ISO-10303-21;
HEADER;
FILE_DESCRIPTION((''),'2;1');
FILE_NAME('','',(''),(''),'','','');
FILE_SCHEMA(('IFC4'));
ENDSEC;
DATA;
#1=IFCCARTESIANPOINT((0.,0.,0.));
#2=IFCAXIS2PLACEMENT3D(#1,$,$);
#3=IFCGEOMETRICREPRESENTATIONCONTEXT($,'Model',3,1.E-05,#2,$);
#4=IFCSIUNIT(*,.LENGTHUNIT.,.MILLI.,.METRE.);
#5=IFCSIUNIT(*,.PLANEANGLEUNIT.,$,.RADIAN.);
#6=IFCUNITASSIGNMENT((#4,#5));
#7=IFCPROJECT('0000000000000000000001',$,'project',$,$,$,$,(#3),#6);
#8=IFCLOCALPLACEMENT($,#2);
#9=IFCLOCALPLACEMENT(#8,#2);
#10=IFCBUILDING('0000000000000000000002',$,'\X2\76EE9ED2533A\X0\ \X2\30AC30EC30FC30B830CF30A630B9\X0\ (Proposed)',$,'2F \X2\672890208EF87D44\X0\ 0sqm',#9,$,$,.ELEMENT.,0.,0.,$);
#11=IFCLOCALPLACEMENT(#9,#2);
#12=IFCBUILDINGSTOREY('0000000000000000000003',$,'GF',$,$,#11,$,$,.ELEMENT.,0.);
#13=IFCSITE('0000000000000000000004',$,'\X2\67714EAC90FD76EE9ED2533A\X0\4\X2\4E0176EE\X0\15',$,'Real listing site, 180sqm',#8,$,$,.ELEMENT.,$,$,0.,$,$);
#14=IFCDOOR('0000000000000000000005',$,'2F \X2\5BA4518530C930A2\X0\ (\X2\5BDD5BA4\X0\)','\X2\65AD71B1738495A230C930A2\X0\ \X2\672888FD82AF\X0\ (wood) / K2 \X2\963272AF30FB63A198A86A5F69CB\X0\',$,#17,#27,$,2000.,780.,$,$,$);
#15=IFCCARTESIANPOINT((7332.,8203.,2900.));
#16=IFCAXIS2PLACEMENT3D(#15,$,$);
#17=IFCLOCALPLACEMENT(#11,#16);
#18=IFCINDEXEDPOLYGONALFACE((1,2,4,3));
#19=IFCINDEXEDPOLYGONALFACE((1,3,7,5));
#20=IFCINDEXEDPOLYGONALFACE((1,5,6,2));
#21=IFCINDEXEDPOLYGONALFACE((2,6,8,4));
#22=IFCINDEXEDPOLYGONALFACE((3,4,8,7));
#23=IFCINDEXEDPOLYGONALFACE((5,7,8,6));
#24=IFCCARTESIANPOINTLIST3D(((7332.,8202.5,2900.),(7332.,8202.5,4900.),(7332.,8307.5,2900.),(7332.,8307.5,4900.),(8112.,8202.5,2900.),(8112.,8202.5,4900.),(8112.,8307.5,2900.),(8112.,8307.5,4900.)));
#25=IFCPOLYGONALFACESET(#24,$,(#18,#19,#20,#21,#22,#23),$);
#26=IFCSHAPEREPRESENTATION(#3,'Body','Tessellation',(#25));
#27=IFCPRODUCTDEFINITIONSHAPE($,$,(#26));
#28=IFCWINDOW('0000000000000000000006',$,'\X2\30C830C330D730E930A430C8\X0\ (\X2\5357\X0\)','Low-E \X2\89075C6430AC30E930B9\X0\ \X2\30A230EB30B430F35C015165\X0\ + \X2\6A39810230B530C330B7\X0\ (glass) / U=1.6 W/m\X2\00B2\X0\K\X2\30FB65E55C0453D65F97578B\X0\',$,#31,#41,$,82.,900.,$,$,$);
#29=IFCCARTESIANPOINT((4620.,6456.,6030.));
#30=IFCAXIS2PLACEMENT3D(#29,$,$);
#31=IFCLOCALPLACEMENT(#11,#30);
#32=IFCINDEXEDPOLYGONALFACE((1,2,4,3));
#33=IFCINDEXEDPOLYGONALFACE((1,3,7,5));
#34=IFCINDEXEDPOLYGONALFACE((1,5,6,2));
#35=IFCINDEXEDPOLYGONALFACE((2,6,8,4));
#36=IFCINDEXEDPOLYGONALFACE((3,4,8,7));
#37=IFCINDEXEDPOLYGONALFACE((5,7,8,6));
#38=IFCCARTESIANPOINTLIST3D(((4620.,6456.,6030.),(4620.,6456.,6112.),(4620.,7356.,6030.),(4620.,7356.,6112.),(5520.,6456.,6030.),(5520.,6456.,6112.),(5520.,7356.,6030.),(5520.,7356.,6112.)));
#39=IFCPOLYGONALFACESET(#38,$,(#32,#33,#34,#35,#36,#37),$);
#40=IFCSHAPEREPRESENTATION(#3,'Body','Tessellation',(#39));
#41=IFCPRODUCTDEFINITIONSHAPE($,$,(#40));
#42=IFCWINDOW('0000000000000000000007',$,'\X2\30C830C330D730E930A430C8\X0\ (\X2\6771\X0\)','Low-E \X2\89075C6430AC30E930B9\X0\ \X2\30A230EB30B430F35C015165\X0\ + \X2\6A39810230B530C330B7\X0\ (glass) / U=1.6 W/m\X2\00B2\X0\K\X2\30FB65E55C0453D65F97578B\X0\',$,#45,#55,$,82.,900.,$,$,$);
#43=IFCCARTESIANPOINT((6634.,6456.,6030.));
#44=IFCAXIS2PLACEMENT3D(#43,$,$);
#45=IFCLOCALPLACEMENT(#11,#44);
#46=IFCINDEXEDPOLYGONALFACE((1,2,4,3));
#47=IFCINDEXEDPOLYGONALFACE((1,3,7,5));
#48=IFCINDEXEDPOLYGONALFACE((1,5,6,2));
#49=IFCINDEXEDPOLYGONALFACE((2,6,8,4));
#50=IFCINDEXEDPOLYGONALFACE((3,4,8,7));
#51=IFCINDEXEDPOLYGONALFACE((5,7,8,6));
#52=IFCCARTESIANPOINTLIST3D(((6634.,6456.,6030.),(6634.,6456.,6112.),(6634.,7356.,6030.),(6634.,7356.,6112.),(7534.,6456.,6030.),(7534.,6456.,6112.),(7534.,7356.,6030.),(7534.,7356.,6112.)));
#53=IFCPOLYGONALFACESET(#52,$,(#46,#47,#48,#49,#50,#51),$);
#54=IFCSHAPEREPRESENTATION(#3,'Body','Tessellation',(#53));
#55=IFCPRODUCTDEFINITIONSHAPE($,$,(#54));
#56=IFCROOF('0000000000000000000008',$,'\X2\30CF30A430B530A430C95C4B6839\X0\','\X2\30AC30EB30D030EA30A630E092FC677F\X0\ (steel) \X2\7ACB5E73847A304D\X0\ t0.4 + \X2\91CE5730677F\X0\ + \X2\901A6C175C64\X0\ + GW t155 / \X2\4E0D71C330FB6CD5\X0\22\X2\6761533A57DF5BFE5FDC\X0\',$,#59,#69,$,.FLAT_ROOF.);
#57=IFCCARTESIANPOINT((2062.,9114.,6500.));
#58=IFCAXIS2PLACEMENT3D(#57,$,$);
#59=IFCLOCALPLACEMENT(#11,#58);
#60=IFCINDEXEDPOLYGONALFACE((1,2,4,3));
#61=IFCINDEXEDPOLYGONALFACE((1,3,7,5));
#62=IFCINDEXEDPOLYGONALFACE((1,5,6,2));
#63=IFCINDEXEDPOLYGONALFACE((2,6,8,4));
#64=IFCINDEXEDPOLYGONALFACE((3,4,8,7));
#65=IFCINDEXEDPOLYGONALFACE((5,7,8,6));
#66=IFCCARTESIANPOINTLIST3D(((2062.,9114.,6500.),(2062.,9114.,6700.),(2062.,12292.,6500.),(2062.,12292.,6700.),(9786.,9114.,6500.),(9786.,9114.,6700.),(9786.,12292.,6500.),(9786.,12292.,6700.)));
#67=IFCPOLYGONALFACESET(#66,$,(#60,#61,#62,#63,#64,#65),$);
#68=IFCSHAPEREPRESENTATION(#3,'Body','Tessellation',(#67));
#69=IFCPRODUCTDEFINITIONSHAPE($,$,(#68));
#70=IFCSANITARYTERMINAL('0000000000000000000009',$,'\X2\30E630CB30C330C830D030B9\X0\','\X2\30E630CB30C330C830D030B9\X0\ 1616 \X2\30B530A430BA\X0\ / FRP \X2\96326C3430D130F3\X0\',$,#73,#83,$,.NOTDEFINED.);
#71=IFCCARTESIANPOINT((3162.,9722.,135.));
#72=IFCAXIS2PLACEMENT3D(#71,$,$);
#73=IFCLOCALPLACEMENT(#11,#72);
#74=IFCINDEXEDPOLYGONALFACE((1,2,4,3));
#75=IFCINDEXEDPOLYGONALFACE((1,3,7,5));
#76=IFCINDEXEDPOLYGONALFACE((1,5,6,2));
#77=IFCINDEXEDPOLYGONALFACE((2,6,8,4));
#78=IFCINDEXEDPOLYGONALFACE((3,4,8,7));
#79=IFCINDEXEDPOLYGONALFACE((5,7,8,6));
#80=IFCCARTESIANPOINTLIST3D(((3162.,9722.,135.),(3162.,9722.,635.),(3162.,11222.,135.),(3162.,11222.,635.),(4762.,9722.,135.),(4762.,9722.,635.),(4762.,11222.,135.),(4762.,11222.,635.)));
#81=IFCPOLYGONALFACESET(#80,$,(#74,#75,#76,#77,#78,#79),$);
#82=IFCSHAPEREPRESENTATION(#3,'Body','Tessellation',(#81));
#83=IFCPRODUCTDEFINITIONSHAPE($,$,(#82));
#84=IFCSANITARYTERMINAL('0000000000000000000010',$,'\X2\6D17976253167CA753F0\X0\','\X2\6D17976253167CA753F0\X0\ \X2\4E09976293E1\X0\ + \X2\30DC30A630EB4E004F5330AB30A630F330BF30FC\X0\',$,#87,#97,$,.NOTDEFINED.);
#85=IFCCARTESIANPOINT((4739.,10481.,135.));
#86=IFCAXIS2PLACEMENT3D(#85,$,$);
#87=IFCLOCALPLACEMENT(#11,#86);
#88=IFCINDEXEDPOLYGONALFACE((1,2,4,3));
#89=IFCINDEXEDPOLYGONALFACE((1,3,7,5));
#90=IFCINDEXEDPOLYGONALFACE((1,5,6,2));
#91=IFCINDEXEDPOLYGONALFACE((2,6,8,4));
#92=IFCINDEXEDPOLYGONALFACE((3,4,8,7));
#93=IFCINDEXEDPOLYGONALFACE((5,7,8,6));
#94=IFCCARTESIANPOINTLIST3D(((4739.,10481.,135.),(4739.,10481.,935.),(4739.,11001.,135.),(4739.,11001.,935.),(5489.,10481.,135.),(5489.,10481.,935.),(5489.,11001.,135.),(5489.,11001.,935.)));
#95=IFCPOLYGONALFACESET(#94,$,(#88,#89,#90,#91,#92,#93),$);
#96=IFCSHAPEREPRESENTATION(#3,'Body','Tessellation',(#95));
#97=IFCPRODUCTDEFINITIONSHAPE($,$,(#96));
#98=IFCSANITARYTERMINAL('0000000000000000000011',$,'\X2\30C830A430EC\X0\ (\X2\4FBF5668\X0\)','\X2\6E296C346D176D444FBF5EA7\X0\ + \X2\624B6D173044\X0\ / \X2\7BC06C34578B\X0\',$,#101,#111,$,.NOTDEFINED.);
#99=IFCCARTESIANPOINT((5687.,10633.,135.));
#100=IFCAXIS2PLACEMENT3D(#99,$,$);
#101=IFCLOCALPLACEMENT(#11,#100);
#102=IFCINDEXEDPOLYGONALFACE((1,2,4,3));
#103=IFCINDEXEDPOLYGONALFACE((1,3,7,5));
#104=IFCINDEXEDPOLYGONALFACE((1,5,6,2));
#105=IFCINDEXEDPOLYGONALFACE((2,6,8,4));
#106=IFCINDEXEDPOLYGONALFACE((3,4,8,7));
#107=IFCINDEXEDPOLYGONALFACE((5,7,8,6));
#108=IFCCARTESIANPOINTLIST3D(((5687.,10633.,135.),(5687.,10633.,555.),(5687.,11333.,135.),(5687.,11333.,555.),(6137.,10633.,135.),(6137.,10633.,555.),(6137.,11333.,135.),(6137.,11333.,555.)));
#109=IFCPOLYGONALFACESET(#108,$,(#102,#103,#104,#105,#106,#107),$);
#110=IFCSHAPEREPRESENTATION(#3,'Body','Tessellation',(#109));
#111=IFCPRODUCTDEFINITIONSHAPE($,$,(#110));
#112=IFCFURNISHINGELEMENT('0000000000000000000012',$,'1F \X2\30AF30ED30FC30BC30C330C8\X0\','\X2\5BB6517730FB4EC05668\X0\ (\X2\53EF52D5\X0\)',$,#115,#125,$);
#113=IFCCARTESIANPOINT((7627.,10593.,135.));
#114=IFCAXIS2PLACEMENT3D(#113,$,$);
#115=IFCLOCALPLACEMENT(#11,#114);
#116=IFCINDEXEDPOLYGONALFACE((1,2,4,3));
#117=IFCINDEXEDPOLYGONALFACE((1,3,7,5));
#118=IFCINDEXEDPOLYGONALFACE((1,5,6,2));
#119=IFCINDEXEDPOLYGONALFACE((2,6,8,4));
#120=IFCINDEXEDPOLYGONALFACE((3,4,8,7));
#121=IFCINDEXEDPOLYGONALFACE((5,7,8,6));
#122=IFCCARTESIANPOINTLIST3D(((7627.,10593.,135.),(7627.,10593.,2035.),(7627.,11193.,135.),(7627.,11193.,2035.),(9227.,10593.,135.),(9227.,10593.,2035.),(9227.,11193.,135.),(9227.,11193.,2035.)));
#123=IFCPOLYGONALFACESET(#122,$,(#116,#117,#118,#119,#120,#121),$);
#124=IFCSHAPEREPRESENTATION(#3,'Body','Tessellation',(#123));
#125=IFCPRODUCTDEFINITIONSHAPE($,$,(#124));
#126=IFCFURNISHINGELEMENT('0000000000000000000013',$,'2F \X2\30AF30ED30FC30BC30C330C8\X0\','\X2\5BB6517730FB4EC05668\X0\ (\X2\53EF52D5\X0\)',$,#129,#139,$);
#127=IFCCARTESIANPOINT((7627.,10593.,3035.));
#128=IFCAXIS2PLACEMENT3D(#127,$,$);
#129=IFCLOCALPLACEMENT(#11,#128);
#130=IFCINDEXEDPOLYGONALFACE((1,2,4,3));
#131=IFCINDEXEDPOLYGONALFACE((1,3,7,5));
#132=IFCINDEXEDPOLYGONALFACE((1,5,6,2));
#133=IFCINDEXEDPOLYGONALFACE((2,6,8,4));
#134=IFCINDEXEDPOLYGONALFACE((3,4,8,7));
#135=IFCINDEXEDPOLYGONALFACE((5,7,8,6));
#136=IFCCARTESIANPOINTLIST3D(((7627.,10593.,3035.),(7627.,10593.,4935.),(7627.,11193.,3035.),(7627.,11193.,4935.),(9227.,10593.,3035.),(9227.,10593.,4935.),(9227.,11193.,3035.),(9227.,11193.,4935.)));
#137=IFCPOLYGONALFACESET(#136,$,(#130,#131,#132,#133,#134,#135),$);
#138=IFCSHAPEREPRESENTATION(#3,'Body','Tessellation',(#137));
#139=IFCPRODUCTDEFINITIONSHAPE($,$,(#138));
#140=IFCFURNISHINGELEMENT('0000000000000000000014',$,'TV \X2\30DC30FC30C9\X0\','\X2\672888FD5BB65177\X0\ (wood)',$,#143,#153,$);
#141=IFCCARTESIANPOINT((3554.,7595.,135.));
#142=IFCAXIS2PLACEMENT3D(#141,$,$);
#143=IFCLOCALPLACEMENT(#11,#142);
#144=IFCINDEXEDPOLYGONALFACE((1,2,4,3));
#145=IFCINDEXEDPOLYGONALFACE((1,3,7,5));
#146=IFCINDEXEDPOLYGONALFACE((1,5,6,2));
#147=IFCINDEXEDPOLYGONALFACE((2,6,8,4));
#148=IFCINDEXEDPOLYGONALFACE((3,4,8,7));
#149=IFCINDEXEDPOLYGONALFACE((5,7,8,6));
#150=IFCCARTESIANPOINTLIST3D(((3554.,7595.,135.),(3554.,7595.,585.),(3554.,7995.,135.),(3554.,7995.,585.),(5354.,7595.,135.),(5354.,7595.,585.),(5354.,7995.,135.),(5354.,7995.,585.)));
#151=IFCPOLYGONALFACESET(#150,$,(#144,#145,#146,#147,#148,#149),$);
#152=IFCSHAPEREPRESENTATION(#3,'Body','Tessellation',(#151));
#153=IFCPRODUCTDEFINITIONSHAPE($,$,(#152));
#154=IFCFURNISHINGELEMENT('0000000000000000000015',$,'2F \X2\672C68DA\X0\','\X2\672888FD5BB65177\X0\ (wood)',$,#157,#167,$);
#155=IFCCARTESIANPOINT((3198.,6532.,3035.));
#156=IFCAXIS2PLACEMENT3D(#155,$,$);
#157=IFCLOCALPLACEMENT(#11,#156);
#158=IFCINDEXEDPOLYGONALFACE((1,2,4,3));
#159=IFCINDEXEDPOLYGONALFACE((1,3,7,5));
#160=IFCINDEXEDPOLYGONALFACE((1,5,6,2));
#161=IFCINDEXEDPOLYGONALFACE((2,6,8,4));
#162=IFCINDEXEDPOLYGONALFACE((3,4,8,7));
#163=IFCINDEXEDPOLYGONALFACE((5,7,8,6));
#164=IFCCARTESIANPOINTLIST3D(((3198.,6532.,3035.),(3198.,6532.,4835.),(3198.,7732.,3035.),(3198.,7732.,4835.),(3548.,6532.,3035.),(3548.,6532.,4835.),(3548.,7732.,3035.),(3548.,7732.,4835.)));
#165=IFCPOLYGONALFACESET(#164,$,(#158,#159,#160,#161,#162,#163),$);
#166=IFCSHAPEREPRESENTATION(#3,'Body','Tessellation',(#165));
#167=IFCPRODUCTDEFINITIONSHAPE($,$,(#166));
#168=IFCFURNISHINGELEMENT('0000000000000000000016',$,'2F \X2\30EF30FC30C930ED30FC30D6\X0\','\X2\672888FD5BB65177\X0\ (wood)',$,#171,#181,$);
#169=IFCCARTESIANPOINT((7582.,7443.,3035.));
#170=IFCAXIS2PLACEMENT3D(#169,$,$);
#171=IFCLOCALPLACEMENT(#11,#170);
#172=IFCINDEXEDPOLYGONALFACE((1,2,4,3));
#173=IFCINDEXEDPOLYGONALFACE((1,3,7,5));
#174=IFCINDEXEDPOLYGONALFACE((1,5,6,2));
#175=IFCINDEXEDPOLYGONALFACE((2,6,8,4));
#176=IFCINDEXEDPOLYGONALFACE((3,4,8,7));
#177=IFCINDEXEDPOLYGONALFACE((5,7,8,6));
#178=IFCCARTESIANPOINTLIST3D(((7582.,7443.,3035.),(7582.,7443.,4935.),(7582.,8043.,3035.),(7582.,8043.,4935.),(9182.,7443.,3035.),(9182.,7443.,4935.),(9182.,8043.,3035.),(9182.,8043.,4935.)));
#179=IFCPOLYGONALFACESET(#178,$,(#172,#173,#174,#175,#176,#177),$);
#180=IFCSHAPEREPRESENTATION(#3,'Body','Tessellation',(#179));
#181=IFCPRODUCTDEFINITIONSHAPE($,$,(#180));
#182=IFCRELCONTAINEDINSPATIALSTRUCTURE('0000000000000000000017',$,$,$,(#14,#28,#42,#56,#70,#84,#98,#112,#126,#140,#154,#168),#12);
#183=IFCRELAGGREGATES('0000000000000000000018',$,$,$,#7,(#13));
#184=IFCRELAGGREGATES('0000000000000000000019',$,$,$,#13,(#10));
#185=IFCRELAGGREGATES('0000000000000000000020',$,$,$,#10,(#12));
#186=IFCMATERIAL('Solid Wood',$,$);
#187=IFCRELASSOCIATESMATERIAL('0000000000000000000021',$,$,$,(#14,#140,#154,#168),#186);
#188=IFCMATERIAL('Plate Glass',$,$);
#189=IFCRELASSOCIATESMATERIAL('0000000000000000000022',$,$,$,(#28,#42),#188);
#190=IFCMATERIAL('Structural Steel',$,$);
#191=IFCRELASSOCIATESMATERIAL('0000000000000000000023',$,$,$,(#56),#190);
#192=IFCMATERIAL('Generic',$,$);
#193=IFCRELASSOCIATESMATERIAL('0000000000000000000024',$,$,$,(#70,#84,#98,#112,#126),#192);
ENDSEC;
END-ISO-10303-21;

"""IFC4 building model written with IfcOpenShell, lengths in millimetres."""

from ifc_helpers import new_model, si_unit, frame, frame_2d, origin, place, context, project, spatial, rectangle, extrude, material, element, save


model = new_model("IFC4")

# Units and contexts
model_context = context("Model", 3, precision=1e-05, world=origin())
ifc_project = project(units=[si_unit("LENGTHUNIT", "METRE", prefix="MILLI"), si_unit("PLANEANGLEUNIT", "RADIAN")], contexts=[model_context])

# Site, building, storey
site_placement = place(None, origin())
site = spatial("IfcSite", under=ifc_project, at=site_placement, Name="東京都目黒区4丁目15", ObjectType="Real listing site, 180sqm", CompositionType="ELEMENT", RefElevation=0.0)
building_placement = place(site_placement, origin())
building = spatial("IfcBuilding", under=site, at=building_placement, Name="目黒区 ガレージハウス (Proposed)", ObjectType="2F 木造軸組 0sqm", CompositionType="ELEMENT", ElevationOfRefHeight=0.0, ElevationOfTerrain=0.0)
storey_placement = place(building_placement, origin())
storey = spatial("IfcBuildingStorey", under=building, at=storey_placement, Name="GF", CompositionType="ELEMENT", Elevation=0.0)

# Shared definitions
ifc_material_1 = material(Name="Solid Wood")
ifc_material_2 = material(Name="Plate Glass")

# Door
door_1_placement = place(storey_placement, frame((7332.0, 8203.0, 2900.0)))
element("IfcDoor", 1, at=door_1_placement, inside=storey, material=ifc_material_1, Name="2F 室内ドア (寝室)", Description="断熱玄関ドア 木製芯 (wood) / K2 防犯・採風機構", OverallHeight=2000.0, OverallWidth=780.0, context=model_context, shape_type="SweptSolid", body=[
    extrude(rectangle(XDim=780.0, YDim=105.0, at=frame_2d((390.0, 52.0))), frame((7332.0, 8203.0, 2900.0)), (0.0, 0.0, 1.0), 2000.0),
])

# Windows
window_1_placement = place(storey_placement, frame((4620.0, 6456.0, 6030.0)))
element("IfcWindow", 2, at=window_1_placement, inside=storey, material=ifc_material_2, Name="トップライト (南)", Description="Low-E 複層ガラス アルゴン封入 + 樹脂サッシ (glass) / U=1.6 W/m²K・日射取得型", OverallHeight=82.0, OverallWidth=900.0, context=model_context, shape_type="SweptSolid", body=[
    extrude(rectangle(XDim=900.0, YDim=900.0, at=frame_2d((450.0, 450.0))), frame((4620.0, 6456.0, 6030.0)), (0.0, 0.0, 1.0), 82.0),
])
window_2_placement = place(storey_placement, frame((6634.0, 6456.0, 6030.0)))
element("IfcWindow", 3, at=window_2_placement, inside=storey, material=ifc_material_2, Name="トップライト (東)", Description="Low-E 複層ガラス アルゴン封入 + 樹脂サッシ (glass) / U=1.6 W/m²K・日射取得型", OverallHeight=82.0, OverallWidth=900.0, context=model_context, shape_type="SweptSolid", body=[
    extrude(rectangle(XDim=900.0, YDim=900.0, at=frame_2d((450.0, 450.0))), frame((6634.0, 6456.0, 6030.0)), (0.0, 0.0, 1.0), 82.0),
])

# Roof
ifc_material_3 = material(Name="Structural Steel")
roof_placement = place(storey_placement, frame((2062.0, 9114.0, 6500.0)))
element("IfcRoof", 4, at=roof_placement, inside=storey, material=ifc_material_3, Name="ハイサイド屋根", Description="ガルバリウム鋼板 (steel) 立平葺き t0.4 + 野地板 + 通気層 + GW t155 / 不燃・法22条区域対応", PredefinedType="FLAT_ROOF", context=model_context, shape_type="SweptSolid", body=[
    extrude(rectangle(XDim=7724.0, YDim=3178.0, at=frame_2d((3862.0, 1589.0))), frame((2062.0, 9114.0, 6500.0)), (0.0, 0.0, 1.0), 200.0),
])

# Sanitary terminals
ifc_material_4 = material(Name="Generic")
sanitary_terminal_1_placement = place(storey_placement, frame((3162.0, 9722.0, 135.0)))
element("IfcSanitaryTerminal", 5, at=sanitary_terminal_1_placement, inside=storey, material=ifc_material_4, Name="ユニットバス", Description="ユニットバス 1616 サイズ / FRP 防水パン", PredefinedType="NOTDEFINED", context=model_context, shape_type="SweptSolid", body=[
    extrude(rectangle(XDim=1600.0, YDim=1500.0, at=frame_2d((800.0, 750.0))), frame((3162.0, 9722.0, 135.0)), (0.0, 0.0, 1.0), 500.0),
])
sanitary_terminal_2_placement = place(storey_placement, frame((4739.0, 10481.0, 135.0)))
element("IfcSanitaryTerminal", 6, at=sanitary_terminal_2_placement, inside=storey, material=ifc_material_4, Name="洗面化粧台", Description="洗面化粧台 三面鏡 + ボウル一体カウンター", PredefinedType="NOTDEFINED", context=model_context, shape_type="SweptSolid", body=[
    extrude(rectangle(XDim=750.0, YDim=520.0, at=frame_2d((375.0, 260.0))), frame((4739.0, 10481.0, 135.0)), (0.0, 0.0, 1.0), 800.0),
])
sanitary_terminal_3_placement = place(storey_placement, frame((5687.0, 10633.0, 135.0)))
element("IfcSanitaryTerminal", 7, at=sanitary_terminal_3_placement, inside=storey, material=ifc_material_4, Name="トイレ (便器)", Description="温水洗浄便座 + 手洗い / 節水型", PredefinedType="NOTDEFINED", context=model_context, shape_type="SweptSolid", body=[
    extrude(rectangle(XDim=450.0, YDim=700.0, at=frame_2d((225.0, 350.0))), frame((5687.0, 10633.0, 135.0)), (0.0, 0.0, 1.0), 420.0),
])

# Furnishing elements
furnishing_1_placement = place(storey_placement, frame((7627.0, 10593.0, 135.0)))
element("IfcFurnishingElement", 8, at=furnishing_1_placement, inside=storey, material=ifc_material_4, Name="1F クローゼット", Description="家具・什器 (可動)", context=model_context, shape_type="SweptSolid", body=[
    extrude(rectangle(XDim=1600.0, YDim=600.0, at=frame_2d((800.0, 300.0))), frame((7627.0, 10593.0, 135.0)), (0.0, 0.0, 1.0), 1900.0),
])
furnishing_2_placement = place(storey_placement, frame((7627.0, 10593.0, 3035.0)))
element("IfcFurnishingElement", 9, at=furnishing_2_placement, inside=storey, material=ifc_material_4, Name="2F クローゼット", Description="家具・什器 (可動)", context=model_context, shape_type="SweptSolid", body=[
    extrude(rectangle(XDim=1600.0, YDim=600.0, at=frame_2d((800.0, 300.0))), frame((7627.0, 10593.0, 3035.0)), (0.0, 0.0, 1.0), 1900.0),
])
furnishing_3_placement = place(storey_placement, frame((3554.0, 7595.0, 135.0)))
element("IfcFurnishingElement", 10, at=furnishing_3_placement, inside=storey, material=ifc_material_1, Name="TV ボード", Description="木製家具 (wood)", context=model_context, shape_type="SweptSolid", body=[
    extrude(rectangle(XDim=1800.0, YDim=400.0, at=frame_2d((900.0, 200.0))), frame((3554.0, 7595.0, 135.0)), (0.0, 0.0, 1.0), 450.0),
])
furnishing_4_placement = place(storey_placement, frame((3198.0, 6532.0, 3035.0)))
element("IfcFurnishingElement", 11, at=furnishing_4_placement, inside=storey, material=ifc_material_1, Name="2F 本棚", Description="木製家具 (wood)", context=model_context, shape_type="SweptSolid", body=[
    extrude(rectangle(XDim=350.0, YDim=1200.0, at=frame_2d((175.0, 600.0))), frame((3198.0, 6532.0, 3035.0)), (0.0, 0.0, 1.0), 1800.0),
])
furnishing_5_placement = place(storey_placement, frame((7582.0, 7443.0, 3035.0)))
element("IfcFurnishingElement", 12, at=furnishing_5_placement, inside=storey, material=ifc_material_1, Name="2F ワードローブ", Description="木製家具 (wood)", context=model_context, shape_type="SweptSolid", body=[
    extrude(rectangle(XDim=1600.0, YDim=600.0, at=frame_2d((800.0, 300.0))), frame((7582.0, 7443.0, 3035.0)), (0.0, 0.0, 1.0), 1900.0),
])

save(model, "model.ifc")
